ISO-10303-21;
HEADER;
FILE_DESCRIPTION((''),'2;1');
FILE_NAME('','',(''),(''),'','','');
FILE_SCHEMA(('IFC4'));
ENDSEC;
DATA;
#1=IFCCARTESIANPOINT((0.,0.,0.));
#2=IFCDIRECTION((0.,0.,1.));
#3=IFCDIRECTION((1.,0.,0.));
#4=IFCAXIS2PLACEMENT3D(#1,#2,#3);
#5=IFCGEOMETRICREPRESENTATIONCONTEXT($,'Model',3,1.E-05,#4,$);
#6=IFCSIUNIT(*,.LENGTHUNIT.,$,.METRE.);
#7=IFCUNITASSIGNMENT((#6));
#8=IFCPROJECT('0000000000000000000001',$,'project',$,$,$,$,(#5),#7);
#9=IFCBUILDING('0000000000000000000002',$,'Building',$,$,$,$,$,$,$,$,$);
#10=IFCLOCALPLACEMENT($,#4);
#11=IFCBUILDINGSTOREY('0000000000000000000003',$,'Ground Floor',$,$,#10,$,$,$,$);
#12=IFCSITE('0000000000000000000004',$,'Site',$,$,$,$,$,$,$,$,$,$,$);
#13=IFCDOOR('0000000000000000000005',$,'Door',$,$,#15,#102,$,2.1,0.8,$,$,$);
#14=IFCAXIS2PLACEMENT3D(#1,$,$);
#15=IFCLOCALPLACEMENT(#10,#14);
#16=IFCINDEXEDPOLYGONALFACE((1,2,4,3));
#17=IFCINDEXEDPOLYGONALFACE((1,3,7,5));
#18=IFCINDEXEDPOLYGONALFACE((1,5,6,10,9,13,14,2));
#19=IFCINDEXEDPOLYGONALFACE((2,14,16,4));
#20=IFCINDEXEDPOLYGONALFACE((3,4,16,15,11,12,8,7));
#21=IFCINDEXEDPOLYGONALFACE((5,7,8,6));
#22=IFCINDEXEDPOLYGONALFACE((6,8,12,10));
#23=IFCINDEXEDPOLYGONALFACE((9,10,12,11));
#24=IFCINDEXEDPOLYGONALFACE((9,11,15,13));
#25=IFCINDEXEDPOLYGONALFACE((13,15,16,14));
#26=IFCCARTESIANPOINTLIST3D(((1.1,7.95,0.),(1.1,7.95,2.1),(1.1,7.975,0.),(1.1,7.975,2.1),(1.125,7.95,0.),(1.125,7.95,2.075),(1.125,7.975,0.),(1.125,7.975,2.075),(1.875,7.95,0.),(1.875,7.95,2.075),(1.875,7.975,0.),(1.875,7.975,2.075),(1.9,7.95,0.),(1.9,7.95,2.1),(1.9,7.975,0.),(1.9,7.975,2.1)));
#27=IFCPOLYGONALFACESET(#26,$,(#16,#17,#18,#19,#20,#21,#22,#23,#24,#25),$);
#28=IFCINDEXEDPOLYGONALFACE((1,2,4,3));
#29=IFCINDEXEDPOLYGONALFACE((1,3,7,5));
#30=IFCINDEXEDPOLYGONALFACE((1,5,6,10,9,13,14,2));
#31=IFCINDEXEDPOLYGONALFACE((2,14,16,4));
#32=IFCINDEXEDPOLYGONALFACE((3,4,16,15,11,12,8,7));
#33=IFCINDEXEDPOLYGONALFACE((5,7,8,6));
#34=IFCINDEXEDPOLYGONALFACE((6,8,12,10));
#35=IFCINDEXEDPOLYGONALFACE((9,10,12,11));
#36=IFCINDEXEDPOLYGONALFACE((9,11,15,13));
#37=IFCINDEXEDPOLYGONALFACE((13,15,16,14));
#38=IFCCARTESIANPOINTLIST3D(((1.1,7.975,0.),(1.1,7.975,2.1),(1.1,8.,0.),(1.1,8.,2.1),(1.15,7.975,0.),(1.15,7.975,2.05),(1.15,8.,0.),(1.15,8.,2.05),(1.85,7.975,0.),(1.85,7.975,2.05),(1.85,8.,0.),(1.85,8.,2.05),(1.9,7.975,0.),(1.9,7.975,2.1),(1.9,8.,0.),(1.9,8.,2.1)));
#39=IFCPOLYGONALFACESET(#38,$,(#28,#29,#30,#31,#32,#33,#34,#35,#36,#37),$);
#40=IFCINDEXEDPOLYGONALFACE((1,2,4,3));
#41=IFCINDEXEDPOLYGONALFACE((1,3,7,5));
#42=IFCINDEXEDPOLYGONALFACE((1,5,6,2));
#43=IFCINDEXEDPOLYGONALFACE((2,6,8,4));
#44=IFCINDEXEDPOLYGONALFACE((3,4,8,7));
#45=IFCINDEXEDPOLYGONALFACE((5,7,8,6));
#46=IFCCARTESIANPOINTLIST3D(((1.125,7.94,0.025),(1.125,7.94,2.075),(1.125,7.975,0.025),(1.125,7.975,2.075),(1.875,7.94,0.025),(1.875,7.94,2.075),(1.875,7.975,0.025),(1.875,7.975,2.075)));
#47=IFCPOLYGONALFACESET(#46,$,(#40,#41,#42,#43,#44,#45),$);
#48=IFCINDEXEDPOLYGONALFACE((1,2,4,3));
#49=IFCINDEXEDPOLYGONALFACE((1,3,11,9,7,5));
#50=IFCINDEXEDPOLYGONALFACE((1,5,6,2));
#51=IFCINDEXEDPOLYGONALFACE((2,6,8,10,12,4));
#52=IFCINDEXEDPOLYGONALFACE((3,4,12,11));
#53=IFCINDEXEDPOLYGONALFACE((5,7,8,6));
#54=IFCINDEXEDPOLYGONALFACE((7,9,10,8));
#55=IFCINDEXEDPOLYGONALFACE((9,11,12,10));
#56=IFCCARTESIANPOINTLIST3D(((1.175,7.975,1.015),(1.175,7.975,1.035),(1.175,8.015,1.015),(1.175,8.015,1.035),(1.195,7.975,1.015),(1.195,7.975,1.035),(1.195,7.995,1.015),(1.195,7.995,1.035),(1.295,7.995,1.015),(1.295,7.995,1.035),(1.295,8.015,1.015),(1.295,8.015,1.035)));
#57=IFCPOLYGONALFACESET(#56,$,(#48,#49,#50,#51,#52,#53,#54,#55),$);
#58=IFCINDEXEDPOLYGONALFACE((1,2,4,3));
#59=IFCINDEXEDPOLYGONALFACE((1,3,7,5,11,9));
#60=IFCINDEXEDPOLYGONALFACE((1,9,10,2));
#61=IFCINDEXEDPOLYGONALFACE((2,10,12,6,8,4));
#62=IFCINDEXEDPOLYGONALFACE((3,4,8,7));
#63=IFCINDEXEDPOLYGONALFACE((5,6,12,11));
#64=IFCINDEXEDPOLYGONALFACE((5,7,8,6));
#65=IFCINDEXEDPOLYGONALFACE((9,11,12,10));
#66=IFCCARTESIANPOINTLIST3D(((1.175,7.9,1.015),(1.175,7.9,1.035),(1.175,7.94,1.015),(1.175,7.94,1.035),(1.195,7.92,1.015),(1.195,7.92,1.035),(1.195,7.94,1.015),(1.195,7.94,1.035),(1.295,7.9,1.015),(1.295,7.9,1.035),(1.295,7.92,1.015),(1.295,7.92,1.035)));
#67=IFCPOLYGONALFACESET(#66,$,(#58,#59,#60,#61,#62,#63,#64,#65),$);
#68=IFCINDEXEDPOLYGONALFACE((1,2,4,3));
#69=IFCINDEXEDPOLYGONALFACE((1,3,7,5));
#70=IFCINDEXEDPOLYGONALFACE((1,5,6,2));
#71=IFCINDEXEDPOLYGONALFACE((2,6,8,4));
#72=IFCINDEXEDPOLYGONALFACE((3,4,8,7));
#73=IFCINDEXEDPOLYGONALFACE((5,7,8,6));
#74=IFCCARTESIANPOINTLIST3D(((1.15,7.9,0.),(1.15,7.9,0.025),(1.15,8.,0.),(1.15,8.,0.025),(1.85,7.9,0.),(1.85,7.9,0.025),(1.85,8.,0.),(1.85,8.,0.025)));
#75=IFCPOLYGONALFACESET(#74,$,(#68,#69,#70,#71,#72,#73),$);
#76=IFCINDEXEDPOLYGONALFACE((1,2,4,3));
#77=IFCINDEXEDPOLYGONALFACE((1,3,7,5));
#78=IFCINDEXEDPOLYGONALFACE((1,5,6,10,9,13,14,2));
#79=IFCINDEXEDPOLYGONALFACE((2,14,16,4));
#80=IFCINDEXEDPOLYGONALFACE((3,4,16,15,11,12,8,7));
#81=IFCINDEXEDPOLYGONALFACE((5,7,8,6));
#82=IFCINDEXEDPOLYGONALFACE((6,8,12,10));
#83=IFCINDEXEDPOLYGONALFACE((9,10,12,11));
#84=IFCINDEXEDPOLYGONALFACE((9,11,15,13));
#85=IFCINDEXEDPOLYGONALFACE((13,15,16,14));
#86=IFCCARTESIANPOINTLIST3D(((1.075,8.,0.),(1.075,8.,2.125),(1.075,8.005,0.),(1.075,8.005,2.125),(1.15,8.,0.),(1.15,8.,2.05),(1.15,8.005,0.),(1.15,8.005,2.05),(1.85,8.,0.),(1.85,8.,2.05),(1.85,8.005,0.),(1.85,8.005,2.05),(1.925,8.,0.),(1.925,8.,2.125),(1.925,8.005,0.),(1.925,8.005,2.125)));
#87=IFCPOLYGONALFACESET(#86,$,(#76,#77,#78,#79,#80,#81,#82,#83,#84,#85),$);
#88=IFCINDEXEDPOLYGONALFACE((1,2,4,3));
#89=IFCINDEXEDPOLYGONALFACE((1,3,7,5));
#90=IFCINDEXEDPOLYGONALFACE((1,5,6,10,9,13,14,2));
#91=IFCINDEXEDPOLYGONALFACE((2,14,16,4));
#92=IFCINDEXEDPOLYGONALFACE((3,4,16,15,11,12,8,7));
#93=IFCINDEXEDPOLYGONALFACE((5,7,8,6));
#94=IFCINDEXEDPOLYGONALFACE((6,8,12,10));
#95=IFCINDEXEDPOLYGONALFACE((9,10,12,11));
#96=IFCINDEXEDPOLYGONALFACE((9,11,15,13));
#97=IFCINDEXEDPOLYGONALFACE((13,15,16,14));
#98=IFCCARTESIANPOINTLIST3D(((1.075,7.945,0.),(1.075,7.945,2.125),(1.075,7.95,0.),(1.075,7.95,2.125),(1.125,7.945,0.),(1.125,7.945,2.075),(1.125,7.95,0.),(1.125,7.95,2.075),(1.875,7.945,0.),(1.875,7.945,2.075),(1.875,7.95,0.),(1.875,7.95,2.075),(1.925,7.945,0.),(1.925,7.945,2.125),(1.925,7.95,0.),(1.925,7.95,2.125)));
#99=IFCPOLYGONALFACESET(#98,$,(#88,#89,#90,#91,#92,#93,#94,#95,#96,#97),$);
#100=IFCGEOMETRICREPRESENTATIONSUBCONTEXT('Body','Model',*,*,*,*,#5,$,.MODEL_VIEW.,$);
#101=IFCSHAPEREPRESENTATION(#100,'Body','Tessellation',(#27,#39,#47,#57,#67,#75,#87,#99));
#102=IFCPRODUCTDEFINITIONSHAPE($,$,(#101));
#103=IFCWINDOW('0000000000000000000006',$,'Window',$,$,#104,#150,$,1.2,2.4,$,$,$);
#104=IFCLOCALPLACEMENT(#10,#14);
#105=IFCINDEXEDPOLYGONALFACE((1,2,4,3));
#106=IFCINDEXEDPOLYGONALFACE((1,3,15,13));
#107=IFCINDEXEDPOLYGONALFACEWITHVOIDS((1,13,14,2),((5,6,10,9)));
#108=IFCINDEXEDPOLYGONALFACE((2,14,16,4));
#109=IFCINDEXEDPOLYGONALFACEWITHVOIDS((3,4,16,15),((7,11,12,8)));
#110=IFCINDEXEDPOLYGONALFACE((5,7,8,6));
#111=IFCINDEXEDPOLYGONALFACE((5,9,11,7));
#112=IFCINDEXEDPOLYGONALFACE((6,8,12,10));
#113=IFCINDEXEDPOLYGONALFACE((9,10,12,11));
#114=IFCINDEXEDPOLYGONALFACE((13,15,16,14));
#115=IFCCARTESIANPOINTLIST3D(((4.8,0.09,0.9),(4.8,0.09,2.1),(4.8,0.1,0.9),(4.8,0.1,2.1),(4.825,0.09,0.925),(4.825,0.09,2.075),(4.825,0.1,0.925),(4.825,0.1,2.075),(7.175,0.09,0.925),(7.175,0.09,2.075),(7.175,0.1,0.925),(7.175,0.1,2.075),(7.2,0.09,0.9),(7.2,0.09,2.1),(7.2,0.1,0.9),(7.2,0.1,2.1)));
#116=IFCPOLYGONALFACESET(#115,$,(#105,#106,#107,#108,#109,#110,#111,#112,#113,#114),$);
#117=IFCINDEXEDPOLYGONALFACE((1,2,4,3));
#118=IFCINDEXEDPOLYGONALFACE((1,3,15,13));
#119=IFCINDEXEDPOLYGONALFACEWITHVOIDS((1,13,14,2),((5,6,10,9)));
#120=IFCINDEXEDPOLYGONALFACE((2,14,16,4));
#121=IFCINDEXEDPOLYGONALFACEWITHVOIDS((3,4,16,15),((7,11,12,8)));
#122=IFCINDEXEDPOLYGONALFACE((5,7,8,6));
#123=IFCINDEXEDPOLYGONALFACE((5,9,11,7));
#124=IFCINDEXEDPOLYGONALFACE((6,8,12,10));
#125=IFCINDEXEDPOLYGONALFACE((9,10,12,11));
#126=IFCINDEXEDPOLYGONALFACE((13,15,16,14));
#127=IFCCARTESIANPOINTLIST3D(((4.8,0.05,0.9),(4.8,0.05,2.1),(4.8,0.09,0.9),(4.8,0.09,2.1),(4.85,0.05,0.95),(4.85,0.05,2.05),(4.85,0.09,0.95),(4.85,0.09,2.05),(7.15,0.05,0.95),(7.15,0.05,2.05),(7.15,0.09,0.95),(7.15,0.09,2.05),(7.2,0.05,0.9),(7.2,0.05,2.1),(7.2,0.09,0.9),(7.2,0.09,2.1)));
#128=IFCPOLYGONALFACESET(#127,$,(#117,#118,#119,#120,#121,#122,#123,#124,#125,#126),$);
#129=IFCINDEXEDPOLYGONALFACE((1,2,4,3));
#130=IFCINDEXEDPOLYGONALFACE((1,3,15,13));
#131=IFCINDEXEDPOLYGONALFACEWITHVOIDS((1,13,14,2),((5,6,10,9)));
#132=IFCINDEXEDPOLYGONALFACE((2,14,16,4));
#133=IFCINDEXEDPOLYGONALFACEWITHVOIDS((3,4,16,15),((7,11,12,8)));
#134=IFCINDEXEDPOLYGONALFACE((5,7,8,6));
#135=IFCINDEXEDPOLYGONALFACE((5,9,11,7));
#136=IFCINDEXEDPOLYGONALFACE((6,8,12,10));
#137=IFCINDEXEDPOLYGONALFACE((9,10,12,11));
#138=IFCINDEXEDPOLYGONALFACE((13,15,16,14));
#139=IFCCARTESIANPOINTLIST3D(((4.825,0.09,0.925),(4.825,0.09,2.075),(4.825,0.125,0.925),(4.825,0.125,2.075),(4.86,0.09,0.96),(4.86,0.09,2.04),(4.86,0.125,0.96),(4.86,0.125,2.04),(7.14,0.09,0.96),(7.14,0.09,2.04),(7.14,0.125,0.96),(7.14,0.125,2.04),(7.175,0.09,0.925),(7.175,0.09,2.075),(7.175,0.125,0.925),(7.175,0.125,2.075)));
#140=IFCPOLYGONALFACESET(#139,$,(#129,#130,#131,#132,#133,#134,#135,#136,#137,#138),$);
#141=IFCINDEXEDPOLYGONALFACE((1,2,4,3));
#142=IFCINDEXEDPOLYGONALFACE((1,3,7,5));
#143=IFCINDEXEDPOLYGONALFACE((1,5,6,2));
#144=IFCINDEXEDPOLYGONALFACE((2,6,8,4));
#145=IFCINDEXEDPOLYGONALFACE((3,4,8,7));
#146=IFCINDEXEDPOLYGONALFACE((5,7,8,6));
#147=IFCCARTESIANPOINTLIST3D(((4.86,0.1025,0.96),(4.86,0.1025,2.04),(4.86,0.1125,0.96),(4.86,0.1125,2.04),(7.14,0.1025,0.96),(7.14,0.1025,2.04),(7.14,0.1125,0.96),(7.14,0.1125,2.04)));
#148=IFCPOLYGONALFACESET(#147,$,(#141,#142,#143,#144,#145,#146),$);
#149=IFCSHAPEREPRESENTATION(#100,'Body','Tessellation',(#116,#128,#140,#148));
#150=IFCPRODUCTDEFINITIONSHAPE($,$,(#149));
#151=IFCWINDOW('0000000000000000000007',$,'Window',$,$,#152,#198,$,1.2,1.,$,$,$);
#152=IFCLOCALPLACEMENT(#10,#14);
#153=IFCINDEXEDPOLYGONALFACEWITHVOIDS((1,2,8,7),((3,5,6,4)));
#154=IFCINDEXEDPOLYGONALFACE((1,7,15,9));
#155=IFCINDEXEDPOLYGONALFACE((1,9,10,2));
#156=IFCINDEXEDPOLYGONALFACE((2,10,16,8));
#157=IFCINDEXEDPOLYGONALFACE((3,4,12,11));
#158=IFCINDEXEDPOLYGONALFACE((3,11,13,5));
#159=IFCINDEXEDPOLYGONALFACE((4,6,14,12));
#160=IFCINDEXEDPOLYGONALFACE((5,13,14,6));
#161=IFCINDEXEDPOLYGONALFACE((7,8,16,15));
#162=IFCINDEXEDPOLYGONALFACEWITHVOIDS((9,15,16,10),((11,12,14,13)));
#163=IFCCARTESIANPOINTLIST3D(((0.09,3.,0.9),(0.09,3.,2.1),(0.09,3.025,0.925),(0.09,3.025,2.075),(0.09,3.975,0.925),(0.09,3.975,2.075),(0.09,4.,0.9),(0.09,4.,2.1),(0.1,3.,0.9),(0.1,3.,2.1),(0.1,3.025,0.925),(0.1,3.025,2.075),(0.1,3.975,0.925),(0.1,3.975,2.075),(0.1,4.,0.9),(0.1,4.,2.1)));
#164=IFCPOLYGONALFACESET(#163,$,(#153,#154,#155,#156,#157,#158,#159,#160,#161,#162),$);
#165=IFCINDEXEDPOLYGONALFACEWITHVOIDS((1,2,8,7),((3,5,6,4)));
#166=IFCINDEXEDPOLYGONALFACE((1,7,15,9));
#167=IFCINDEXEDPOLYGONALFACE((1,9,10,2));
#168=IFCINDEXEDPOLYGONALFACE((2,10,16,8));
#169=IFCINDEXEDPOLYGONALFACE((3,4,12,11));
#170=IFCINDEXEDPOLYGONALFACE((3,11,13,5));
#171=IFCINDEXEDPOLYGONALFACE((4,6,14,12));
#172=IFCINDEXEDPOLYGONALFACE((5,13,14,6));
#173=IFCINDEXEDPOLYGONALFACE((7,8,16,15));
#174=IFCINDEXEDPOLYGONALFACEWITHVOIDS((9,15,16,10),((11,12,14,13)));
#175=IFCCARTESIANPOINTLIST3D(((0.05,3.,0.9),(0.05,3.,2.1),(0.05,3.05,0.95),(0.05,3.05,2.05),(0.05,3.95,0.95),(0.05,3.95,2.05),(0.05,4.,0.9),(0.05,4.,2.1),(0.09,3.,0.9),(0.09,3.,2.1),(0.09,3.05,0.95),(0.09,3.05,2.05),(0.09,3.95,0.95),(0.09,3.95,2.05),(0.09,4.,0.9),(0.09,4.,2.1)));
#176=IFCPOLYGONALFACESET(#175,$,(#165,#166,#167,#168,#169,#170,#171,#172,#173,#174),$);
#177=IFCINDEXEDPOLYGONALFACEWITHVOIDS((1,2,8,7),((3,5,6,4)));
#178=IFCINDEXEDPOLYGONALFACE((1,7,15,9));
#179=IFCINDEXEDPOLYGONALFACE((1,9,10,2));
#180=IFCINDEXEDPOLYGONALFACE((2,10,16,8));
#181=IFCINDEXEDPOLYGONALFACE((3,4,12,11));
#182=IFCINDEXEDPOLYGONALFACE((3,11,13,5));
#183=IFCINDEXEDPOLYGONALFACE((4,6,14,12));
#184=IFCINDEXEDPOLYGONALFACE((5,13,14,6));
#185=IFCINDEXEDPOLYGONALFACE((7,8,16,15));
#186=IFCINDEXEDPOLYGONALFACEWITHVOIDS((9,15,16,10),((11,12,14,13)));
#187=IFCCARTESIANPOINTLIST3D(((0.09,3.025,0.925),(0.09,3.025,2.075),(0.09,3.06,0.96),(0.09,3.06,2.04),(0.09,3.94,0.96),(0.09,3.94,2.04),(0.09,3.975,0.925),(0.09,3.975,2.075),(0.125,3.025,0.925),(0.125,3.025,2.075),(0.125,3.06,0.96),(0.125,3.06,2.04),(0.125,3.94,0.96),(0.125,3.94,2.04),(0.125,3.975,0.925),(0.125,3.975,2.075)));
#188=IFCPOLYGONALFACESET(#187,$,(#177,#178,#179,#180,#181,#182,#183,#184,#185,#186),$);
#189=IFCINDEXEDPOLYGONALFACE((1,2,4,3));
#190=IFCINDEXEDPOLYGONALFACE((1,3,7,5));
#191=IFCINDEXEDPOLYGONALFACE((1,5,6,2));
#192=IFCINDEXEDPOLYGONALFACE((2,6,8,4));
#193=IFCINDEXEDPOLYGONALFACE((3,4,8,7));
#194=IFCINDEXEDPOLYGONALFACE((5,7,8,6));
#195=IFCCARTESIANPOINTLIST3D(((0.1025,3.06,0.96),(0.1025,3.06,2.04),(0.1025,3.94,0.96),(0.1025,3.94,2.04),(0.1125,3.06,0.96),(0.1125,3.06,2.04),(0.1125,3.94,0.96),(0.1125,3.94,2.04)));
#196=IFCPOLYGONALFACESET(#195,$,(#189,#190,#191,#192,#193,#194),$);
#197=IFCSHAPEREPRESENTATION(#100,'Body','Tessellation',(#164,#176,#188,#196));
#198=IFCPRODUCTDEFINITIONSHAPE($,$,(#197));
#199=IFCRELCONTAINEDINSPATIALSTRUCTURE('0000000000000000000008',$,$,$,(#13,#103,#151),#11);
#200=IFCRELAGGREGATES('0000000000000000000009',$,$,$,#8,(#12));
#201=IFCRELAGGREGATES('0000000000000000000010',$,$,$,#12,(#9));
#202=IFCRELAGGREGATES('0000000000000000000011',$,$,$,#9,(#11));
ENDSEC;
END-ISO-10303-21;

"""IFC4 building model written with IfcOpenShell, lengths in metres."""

from ifc_helpers import new_model, si_unit, frame, origin_with_axes, place, context, subcontext, project, spatial, line, indexed_curve, outline, extrude, element, save


model = new_model("IFC4")

# Units and contexts
model_context = context("Model", 3, precision=1e-05, world=origin_with_axes())
body_context = subcontext(model_context, "Body", "Model", "MODEL_VIEW")
ifc_project = project(units=[si_unit("LENGTHUNIT", "METRE")], contexts=[model_context])

# Site, building, storey
site = spatial("IfcSite", under=ifc_project, Name="Site")
building = spatial("IfcBuilding", under=site, Name="Building")
storey_placement = place(None, origin_with_axes())
storey = spatial("IfcBuildingStorey", under=building, at=storey_placement, Name="Ground Floor")

# Door
door_1_placement = place(storey_placement, frame((1.9, 8.0, 0.0), z_axis=(0.0, 0.0, 1.0), x_axis=(-1.0, 0.0, 0.0)))
element("IfcDoor", 1, at=door_1_placement, inside=storey, Name="Door", OverallHeight=2.1, OverallWidth=0.8, context=body_context, shape_type="SweptSolid", body=[
    extrude(outline(indexed_curve([(0.0, 0.0), (0.0, 2.1), (0.8, 2.1), (0.8, 0.0), (0.775, 0.0), (0.775, 2.075), (0.025, 2.075), (0.025, 0.0)], segments=[line(1, 2, 3, 4, 5, 6, 7, 8, 1)])), frame((0.0, 0.025, 0.0), z_axis=(0.0, -1.0, 0.0), x_axis=(1.0, 0.0, 0.0)), (0.0, 0.0, -1.0), 0.025),
    extrude(outline(indexed_curve([(0.0, 0.0), (0.0, 2.1), (0.8, 2.1), (0.8, 0.0), (0.75, 0.0), (0.75, 2.05), (0.05, 2.05), (0.05, 0.0)], segments=[line(1, 2, 3, 4, 5, 6, 7, 8, 1)])), frame((0.0, 0.0, 0.0), z_axis=(0.0, -1.0, 0.0), x_axis=(1.0, 0.0, 0.0)), (0.0, 0.0, -1.0), 0.025),
    extrude(outline(indexed_curve([(0.0, 0.0), (0.75, 0.0), (0.75, 0.035), (0.0, 0.035)], segments=[line(1, 2, 3, 4, 1)])), frame((0.025, 0.025, 0.025), z_axis=(0.0, 0.0, 1.0), x_axis=(1.0, 0.0, 0.0)), (0.0, 0.0, 1.0), 2.05),
    extrude(outline(indexed_curve([(0.0, 0.0), (0.0, -0.04), (-0.12, -0.04), (-0.12, -0.02), (-0.02, -0.02), (-0.02, 0.0)], segments=[line(1, 2, 3, 4, 5, 6, 1)])), frame((0.725, 0.025, 1.015), z_axis=(0.0, 0.0, 1.0), x_axis=(1.0, 0.0, 0.0)), (0.0, 0.0, 1.0), 0.02),
    extrude(outline(indexed_curve([(0.0, 0.0), (0.0, 0.04), (-0.12, 0.04), (-0.12, 0.02), (-0.02, 0.02), (-0.02, 0.0)], segments=[line(1, 2, 3, 4, 5, 6, 1)])), frame((0.725, 0.06, 1.015), z_axis=(0.0, 0.0, 1.0), x_axis=(1.0, 0.0, 0.0)), (0.0, 0.0, 1.0), 0.02),
    extrude(outline(indexed_curve([(0.0, 0.0), (0.7, 0.0), (0.7, 0.1), (0.0, 0.1)], segments=[line(1, 2, 3, 4, 1)])), frame((0.05, 0.0, 0.0), z_axis=(0.0, 0.0, 1.0), x_axis=(1.0, 0.0, 0.0)), (0.0, 0.0, 1.0), 0.025),
    extrude(outline(indexed_curve([(0.0, 0.0), (0.0, 2.125), (0.85, 2.125), (0.85, 0.0), (0.775, 0.0), (0.775, 2.05), (0.075, 2.05), (0.075, 0.0)], segments=[line(1, 2, 3, 4, 5, 6, 7, 8, 1)])), frame((-0.025, -0.005, 0.0), z_axis=(0.0, -1.0, 0.0), x_axis=(1.0, 0.0, 0.0)), (0.0, 0.0, -1.0), 0.005),
    extrude(outline(indexed_curve([(0.0, 0.0), (0.0, 2.125), (0.85, 2.125), (0.85, 0.0), (0.8, 0.0), (0.8, 2.075), (0.05, 2.075), (0.05, 0.0)], segments=[line(1, 2, 3, 4, 5, 6, 7, 8, 1)])), frame((-0.025, 0.05, 0.0), z_axis=(0.0, -1.0, 0.0), x_axis=(1.0, 0.0, 0.0)), (0.0, 0.0, -1.0), 0.005),
])

# Windows
window_1_placement = place(storey_placement, frame((4.8, 0.0, 0.9), z_axis=(0.0, 0.0, 1.0), x_axis=(1.0, 0.0, 0.0)))
element("IfcWindow", 2, at=window_1_placement, inside=storey, Name="Window", OverallHeight=1.2, OverallWidth=2.4, context=body_context, shape_type="SweptSolid", body=[
    extrude(outline(indexed_curve([(0.0, 0.0), (2.4, 0.0), (2.4, 1.2), (0.0, 1.2)], segments=[line(1, 2, 3, 4, 1)]), holes=[indexed_curve([(0.025, 0.025), (2.375, 0.025), (2.375, 1.175), (0.025, 1.175)], segments=[line(1, 2, 3, 4, 1)])]), frame((0.0, 0.09, 0.0), z_axis=(0.0, -1.0, 0.0), x_axis=(1.0, 0.0, 0.0)), (0.0, 0.0, -1.0), 0.01),
    extrude(outline(indexed_curve([(0.0, 0.0), (2.4, 0.0), (2.4, 1.2), (0.0, 1.2)], segments=[line(1, 2, 3, 4, 1)]), holes=[indexed_curve([(0.05, 0.05), (2.35, 0.05), (2.35, 1.15), (0.05, 1.15)], segments=[line(1, 2, 3, 4, 1)])]), frame((0.0, 0.05, 0.0), z_axis=(0.0, -1.0, 0.0), x_axis=(1.0, 0.0, 0.0)), (0.0, 0.0, -1.0), 0.04),
    extrude(outline(indexed_curve([(0.0, 0.0), (2.35, 0.0), (2.35, 1.15), (0.0, 1.15)], segments=[line(1, 2, 3, 4, 1)]), holes=[indexed_curve([(0.035, 0.035), (2.315, 0.035), (2.315, 1.115), (0.035, 1.115)], segments=[line(1, 2, 3, 4, 1)])]), frame((0.025, 0.09, 0.025), z_axis=(0.0, -1.0, 0.0), x_axis=(1.0, 0.0, 0.0)), (0.0, 0.0, -1.0), 0.035),
    extrude(outline(indexed_curve([(0.035, 0.035), (2.315, 0.035), (2.315, 1.115), (0.035, 1.115)], segments=[line(1, 2, 3, 4, 1)])), frame((0.025, 0.1025, 0.025), z_axis=(0.0, -1.0, 0.0), x_axis=(1.0, 0.0, 0.0)), (0.0, 0.0, -1.0), 0.01),
])
window_2_placement = place(storey_placement, frame((0.0, 4.0, 0.9), z_axis=(0.0, 0.0, 1.0), x_axis=(0.0, -1.0, 0.0)))
element("IfcWindow", 3, at=window_2_placement, inside=storey, Name="Window", OverallHeight=1.2, OverallWidth=1.0, context=body_context, shape_type="SweptSolid", body=[
    extrude(outline(indexed_curve([(0.0, 0.0), (1.0, 0.0), (1.0, 1.2), (0.0, 1.2)], segments=[line(1, 2, 3, 4, 1)]), holes=[indexed_curve([(0.025, 0.025), (0.975, 0.025), (0.975, 1.175), (0.025, 1.175)], segments=[line(1, 2, 3, 4, 1)])]), frame((0.0, 0.09, 0.0), z_axis=(0.0, -1.0, 0.0), x_axis=(1.0, 0.0, 0.0)), (0.0, 0.0, -1.0), 0.01),
    extrude(outline(indexed_curve([(0.0, 0.0), (1.0, 0.0), (1.0, 1.2), (0.0, 1.2)], segments=[line(1, 2, 3, 4, 1)]), holes=[indexed_curve([(0.05, 0.05), (0.95, 0.05), (0.95, 1.15), (0.05, 1.15)], segments=[line(1, 2, 3, 4, 1)])]), frame((0.0, 0.05, 0.0), z_axis=(0.0, -1.0, 0.0), x_axis=(1.0, 0.0, 0.0)), (0.0, 0.0, -1.0), 0.04),
    extrude(outline(indexed_curve([(0.0, 0.0), (0.95, 0.0), (0.95, 1.15), (0.0, 1.15)], segments=[line(1, 2, 3, 4, 1)]), holes=[indexed_curve([(0.035, 0.035), (0.915, 0.035), (0.915, 1.115), (0.035, 1.115)], segments=[line(1, 2, 3, 4, 1)])]), frame((0.025, 0.09, 0.025), z_axis=(0.0, -1.0, 0.0), x_axis=(1.0, 0.0, 0.0)), (0.0, 0.0, -1.0), 0.035),
    extrude(outline(indexed_curve([(0.035, 0.035), (0.915, 0.035), (0.915, 1.115), (0.035, 1.115)], segments=[line(1, 2, 3, 4, 1)])), frame((0.025, 0.1025, 0.025), z_axis=(0.0, -1.0, 0.0), x_axis=(1.0, 0.0, 0.0)), (0.0, 0.0, -1.0), 0.01),
])

save(model, "model.ifc")
